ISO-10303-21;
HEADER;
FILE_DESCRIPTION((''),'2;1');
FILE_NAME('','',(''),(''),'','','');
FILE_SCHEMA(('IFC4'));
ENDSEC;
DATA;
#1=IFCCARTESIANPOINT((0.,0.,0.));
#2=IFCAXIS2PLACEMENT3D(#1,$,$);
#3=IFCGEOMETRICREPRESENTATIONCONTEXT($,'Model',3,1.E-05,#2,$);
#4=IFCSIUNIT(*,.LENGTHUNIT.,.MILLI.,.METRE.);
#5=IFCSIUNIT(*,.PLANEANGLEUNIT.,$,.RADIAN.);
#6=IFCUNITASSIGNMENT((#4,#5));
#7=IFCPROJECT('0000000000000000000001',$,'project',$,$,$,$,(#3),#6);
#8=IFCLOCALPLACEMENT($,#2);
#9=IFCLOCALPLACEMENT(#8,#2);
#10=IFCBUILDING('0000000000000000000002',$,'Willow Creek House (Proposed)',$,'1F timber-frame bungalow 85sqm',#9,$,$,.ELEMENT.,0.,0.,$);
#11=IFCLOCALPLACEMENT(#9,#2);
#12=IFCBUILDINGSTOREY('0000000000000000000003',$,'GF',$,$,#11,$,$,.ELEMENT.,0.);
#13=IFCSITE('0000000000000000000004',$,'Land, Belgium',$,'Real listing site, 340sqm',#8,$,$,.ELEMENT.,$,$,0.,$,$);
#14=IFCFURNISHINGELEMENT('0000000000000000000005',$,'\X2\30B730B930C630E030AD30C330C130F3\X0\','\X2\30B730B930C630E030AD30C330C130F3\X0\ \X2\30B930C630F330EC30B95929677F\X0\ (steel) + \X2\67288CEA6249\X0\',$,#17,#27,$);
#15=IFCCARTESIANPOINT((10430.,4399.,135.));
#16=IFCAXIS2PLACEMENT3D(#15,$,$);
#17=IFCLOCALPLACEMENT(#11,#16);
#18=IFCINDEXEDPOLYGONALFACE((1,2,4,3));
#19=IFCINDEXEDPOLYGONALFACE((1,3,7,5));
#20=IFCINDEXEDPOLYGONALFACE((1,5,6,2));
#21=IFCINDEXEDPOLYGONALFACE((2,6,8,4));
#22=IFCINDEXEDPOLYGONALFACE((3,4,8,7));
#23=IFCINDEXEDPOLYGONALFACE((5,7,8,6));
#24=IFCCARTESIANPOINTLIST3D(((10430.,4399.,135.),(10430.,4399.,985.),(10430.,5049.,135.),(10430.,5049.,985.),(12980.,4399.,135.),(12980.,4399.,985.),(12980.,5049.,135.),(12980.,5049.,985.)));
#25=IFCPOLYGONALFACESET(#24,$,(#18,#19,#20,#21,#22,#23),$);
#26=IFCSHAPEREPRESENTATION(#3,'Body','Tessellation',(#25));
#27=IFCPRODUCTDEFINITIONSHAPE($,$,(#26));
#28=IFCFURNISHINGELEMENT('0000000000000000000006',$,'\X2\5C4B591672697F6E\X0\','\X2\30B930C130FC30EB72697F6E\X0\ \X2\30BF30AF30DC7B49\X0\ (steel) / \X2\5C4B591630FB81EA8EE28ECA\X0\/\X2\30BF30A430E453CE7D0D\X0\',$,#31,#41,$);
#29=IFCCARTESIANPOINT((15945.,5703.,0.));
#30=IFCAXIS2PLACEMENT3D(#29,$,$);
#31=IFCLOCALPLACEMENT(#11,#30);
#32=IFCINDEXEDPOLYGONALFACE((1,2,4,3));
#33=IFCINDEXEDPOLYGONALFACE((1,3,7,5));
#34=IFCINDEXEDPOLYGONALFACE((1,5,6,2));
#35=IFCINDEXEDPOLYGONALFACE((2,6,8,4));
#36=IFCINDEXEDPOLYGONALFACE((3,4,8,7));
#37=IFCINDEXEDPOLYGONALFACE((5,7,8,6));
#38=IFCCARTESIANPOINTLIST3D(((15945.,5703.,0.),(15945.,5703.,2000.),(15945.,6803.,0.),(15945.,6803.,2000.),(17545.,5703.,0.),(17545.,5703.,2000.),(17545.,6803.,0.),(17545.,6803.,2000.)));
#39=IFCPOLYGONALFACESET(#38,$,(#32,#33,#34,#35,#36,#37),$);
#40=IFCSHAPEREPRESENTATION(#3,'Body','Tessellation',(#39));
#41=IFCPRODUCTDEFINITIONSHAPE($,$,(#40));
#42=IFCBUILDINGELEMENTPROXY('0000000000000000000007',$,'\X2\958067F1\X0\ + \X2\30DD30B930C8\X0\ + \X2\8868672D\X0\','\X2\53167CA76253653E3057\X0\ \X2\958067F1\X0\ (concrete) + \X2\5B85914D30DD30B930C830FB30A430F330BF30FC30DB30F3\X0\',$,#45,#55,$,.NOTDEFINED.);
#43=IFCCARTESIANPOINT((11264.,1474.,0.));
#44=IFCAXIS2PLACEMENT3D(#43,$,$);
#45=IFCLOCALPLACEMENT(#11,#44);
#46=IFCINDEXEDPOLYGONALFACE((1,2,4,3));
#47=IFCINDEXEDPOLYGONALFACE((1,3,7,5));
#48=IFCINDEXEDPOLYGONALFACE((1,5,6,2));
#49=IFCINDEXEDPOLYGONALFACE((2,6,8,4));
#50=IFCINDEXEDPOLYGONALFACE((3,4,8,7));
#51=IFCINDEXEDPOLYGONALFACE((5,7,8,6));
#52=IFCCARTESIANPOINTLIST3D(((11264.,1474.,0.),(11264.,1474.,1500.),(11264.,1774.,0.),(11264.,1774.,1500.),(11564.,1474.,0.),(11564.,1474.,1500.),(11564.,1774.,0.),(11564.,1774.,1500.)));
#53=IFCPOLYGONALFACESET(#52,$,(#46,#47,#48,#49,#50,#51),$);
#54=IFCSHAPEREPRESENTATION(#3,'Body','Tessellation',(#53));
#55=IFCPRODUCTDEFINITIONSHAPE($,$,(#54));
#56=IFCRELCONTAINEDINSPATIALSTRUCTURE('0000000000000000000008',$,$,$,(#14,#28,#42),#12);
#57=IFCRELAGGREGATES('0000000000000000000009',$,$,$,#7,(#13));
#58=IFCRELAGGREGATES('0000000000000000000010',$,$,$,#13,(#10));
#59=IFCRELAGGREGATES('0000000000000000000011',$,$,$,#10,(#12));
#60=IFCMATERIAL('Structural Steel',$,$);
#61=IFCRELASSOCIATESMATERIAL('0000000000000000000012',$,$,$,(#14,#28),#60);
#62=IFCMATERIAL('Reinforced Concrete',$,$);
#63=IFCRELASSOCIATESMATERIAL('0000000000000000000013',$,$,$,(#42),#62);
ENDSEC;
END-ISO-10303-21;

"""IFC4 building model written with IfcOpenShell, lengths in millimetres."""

from ifc_helpers import new_model, si_unit, frame, frame_2d, origin, place, context, project, spatial, rectangle, extrude, material, element, save


model = new_model("IFC4")

# Units and contexts
model_context = context("Model", 3, precision=1e-05, world=origin())
ifc_project = project(units=[si_unit("LENGTHUNIT", "METRE", prefix="MILLI"), si_unit("PLANEANGLEUNIT", "RADIAN")], contexts=[model_context])

# Site, building, storey
site_placement = place(None, origin())
site = spatial("IfcSite", under=ifc_project, at=site_placement, Name="Land, Belgium", ObjectType="Real listing site, 340sqm", CompositionType="ELEMENT", RefElevation=0.0)
building_placement = place(site_placement, origin())
building = spatial("IfcBuilding", under=site, at=building_placement, Name="Willow Creek House (Proposed)", ObjectType="1F timber-frame bungalow 85sqm", CompositionType="ELEMENT", ElevationOfRefHeight=0.0, ElevationOfTerrain=0.0)
storey_placement = place(building_placement, origin())
storey = spatial("IfcBuildingStorey", under=building, at=storey_placement, Name="GF", CompositionType="ELEMENT", Elevation=0.0)

# Shared definitions
ifc_material_1 = material(Name="Reinforced Concrete")

# Shared definitions
ifc_material_2 = material(Name="Structural Steel")

# Furnishing elements
furnishing_1_placement = place(storey_placement, frame((10430.0, 4399.0, 135.0)))
element("IfcFurnishingElement", 1, at=furnishing_1_placement, inside=storey, material=ifc_material_2, Name="システムキッチン", Description="システムキッチン ステンレス天板 (steel) + 木質扉", context=model_context, shape_type="SweptSolid", body=[
    extrude(rectangle(XDim=2550.0, YDim=650.0, at=frame_2d((1275.0, 325.0))), frame((10430.0, 4399.0, 135.0)), (0.0, 0.0, 1.0), 850.0),
])
furnishing_2_placement = place(storey_placement, frame((15945.0, 5703.0, 0.0)))
element("IfcFurnishingElement", 2, at=furnishing_2_placement, inside=storey, material=ifc_material_2, Name="屋外物置", Description="スチール物置 タクボ等 (steel) / 屋外・自転車/タイヤ収納", context=model_context, shape_type="SweptSolid", body=[
    extrude(rectangle(XDim=1600.0, YDim=1100.0, at=frame_2d((800.0, 550.0))), frame((15945.0, 5703.0, 0.0)), (0.0, 0.0, 1.0), 2000.0),
])

# Building element proxy
proxy_placement = place(storey_placement, frame((11264.0, 1474.0, 0.0)))
element("IfcBuildingElementProxy", 3, at=proxy_placement, inside=storey, material=ifc_material_1, Name="門柱 + ポスト + 表札", Description="化粧打放し 門柱 (concrete) + 宅配ポスト・インターホン", PredefinedType="NOTDEFINED", context=model_context, shape_type="SweptSolid", body=[
    extrude(rectangle(XDim=300.0, YDim=300.0, at=frame_2d((150.0, 150.0))), frame((11264.0, 1474.0, 0.0)), (0.0, 0.0, 1.0), 1500.0),
])

save(model, "model.ifc")
